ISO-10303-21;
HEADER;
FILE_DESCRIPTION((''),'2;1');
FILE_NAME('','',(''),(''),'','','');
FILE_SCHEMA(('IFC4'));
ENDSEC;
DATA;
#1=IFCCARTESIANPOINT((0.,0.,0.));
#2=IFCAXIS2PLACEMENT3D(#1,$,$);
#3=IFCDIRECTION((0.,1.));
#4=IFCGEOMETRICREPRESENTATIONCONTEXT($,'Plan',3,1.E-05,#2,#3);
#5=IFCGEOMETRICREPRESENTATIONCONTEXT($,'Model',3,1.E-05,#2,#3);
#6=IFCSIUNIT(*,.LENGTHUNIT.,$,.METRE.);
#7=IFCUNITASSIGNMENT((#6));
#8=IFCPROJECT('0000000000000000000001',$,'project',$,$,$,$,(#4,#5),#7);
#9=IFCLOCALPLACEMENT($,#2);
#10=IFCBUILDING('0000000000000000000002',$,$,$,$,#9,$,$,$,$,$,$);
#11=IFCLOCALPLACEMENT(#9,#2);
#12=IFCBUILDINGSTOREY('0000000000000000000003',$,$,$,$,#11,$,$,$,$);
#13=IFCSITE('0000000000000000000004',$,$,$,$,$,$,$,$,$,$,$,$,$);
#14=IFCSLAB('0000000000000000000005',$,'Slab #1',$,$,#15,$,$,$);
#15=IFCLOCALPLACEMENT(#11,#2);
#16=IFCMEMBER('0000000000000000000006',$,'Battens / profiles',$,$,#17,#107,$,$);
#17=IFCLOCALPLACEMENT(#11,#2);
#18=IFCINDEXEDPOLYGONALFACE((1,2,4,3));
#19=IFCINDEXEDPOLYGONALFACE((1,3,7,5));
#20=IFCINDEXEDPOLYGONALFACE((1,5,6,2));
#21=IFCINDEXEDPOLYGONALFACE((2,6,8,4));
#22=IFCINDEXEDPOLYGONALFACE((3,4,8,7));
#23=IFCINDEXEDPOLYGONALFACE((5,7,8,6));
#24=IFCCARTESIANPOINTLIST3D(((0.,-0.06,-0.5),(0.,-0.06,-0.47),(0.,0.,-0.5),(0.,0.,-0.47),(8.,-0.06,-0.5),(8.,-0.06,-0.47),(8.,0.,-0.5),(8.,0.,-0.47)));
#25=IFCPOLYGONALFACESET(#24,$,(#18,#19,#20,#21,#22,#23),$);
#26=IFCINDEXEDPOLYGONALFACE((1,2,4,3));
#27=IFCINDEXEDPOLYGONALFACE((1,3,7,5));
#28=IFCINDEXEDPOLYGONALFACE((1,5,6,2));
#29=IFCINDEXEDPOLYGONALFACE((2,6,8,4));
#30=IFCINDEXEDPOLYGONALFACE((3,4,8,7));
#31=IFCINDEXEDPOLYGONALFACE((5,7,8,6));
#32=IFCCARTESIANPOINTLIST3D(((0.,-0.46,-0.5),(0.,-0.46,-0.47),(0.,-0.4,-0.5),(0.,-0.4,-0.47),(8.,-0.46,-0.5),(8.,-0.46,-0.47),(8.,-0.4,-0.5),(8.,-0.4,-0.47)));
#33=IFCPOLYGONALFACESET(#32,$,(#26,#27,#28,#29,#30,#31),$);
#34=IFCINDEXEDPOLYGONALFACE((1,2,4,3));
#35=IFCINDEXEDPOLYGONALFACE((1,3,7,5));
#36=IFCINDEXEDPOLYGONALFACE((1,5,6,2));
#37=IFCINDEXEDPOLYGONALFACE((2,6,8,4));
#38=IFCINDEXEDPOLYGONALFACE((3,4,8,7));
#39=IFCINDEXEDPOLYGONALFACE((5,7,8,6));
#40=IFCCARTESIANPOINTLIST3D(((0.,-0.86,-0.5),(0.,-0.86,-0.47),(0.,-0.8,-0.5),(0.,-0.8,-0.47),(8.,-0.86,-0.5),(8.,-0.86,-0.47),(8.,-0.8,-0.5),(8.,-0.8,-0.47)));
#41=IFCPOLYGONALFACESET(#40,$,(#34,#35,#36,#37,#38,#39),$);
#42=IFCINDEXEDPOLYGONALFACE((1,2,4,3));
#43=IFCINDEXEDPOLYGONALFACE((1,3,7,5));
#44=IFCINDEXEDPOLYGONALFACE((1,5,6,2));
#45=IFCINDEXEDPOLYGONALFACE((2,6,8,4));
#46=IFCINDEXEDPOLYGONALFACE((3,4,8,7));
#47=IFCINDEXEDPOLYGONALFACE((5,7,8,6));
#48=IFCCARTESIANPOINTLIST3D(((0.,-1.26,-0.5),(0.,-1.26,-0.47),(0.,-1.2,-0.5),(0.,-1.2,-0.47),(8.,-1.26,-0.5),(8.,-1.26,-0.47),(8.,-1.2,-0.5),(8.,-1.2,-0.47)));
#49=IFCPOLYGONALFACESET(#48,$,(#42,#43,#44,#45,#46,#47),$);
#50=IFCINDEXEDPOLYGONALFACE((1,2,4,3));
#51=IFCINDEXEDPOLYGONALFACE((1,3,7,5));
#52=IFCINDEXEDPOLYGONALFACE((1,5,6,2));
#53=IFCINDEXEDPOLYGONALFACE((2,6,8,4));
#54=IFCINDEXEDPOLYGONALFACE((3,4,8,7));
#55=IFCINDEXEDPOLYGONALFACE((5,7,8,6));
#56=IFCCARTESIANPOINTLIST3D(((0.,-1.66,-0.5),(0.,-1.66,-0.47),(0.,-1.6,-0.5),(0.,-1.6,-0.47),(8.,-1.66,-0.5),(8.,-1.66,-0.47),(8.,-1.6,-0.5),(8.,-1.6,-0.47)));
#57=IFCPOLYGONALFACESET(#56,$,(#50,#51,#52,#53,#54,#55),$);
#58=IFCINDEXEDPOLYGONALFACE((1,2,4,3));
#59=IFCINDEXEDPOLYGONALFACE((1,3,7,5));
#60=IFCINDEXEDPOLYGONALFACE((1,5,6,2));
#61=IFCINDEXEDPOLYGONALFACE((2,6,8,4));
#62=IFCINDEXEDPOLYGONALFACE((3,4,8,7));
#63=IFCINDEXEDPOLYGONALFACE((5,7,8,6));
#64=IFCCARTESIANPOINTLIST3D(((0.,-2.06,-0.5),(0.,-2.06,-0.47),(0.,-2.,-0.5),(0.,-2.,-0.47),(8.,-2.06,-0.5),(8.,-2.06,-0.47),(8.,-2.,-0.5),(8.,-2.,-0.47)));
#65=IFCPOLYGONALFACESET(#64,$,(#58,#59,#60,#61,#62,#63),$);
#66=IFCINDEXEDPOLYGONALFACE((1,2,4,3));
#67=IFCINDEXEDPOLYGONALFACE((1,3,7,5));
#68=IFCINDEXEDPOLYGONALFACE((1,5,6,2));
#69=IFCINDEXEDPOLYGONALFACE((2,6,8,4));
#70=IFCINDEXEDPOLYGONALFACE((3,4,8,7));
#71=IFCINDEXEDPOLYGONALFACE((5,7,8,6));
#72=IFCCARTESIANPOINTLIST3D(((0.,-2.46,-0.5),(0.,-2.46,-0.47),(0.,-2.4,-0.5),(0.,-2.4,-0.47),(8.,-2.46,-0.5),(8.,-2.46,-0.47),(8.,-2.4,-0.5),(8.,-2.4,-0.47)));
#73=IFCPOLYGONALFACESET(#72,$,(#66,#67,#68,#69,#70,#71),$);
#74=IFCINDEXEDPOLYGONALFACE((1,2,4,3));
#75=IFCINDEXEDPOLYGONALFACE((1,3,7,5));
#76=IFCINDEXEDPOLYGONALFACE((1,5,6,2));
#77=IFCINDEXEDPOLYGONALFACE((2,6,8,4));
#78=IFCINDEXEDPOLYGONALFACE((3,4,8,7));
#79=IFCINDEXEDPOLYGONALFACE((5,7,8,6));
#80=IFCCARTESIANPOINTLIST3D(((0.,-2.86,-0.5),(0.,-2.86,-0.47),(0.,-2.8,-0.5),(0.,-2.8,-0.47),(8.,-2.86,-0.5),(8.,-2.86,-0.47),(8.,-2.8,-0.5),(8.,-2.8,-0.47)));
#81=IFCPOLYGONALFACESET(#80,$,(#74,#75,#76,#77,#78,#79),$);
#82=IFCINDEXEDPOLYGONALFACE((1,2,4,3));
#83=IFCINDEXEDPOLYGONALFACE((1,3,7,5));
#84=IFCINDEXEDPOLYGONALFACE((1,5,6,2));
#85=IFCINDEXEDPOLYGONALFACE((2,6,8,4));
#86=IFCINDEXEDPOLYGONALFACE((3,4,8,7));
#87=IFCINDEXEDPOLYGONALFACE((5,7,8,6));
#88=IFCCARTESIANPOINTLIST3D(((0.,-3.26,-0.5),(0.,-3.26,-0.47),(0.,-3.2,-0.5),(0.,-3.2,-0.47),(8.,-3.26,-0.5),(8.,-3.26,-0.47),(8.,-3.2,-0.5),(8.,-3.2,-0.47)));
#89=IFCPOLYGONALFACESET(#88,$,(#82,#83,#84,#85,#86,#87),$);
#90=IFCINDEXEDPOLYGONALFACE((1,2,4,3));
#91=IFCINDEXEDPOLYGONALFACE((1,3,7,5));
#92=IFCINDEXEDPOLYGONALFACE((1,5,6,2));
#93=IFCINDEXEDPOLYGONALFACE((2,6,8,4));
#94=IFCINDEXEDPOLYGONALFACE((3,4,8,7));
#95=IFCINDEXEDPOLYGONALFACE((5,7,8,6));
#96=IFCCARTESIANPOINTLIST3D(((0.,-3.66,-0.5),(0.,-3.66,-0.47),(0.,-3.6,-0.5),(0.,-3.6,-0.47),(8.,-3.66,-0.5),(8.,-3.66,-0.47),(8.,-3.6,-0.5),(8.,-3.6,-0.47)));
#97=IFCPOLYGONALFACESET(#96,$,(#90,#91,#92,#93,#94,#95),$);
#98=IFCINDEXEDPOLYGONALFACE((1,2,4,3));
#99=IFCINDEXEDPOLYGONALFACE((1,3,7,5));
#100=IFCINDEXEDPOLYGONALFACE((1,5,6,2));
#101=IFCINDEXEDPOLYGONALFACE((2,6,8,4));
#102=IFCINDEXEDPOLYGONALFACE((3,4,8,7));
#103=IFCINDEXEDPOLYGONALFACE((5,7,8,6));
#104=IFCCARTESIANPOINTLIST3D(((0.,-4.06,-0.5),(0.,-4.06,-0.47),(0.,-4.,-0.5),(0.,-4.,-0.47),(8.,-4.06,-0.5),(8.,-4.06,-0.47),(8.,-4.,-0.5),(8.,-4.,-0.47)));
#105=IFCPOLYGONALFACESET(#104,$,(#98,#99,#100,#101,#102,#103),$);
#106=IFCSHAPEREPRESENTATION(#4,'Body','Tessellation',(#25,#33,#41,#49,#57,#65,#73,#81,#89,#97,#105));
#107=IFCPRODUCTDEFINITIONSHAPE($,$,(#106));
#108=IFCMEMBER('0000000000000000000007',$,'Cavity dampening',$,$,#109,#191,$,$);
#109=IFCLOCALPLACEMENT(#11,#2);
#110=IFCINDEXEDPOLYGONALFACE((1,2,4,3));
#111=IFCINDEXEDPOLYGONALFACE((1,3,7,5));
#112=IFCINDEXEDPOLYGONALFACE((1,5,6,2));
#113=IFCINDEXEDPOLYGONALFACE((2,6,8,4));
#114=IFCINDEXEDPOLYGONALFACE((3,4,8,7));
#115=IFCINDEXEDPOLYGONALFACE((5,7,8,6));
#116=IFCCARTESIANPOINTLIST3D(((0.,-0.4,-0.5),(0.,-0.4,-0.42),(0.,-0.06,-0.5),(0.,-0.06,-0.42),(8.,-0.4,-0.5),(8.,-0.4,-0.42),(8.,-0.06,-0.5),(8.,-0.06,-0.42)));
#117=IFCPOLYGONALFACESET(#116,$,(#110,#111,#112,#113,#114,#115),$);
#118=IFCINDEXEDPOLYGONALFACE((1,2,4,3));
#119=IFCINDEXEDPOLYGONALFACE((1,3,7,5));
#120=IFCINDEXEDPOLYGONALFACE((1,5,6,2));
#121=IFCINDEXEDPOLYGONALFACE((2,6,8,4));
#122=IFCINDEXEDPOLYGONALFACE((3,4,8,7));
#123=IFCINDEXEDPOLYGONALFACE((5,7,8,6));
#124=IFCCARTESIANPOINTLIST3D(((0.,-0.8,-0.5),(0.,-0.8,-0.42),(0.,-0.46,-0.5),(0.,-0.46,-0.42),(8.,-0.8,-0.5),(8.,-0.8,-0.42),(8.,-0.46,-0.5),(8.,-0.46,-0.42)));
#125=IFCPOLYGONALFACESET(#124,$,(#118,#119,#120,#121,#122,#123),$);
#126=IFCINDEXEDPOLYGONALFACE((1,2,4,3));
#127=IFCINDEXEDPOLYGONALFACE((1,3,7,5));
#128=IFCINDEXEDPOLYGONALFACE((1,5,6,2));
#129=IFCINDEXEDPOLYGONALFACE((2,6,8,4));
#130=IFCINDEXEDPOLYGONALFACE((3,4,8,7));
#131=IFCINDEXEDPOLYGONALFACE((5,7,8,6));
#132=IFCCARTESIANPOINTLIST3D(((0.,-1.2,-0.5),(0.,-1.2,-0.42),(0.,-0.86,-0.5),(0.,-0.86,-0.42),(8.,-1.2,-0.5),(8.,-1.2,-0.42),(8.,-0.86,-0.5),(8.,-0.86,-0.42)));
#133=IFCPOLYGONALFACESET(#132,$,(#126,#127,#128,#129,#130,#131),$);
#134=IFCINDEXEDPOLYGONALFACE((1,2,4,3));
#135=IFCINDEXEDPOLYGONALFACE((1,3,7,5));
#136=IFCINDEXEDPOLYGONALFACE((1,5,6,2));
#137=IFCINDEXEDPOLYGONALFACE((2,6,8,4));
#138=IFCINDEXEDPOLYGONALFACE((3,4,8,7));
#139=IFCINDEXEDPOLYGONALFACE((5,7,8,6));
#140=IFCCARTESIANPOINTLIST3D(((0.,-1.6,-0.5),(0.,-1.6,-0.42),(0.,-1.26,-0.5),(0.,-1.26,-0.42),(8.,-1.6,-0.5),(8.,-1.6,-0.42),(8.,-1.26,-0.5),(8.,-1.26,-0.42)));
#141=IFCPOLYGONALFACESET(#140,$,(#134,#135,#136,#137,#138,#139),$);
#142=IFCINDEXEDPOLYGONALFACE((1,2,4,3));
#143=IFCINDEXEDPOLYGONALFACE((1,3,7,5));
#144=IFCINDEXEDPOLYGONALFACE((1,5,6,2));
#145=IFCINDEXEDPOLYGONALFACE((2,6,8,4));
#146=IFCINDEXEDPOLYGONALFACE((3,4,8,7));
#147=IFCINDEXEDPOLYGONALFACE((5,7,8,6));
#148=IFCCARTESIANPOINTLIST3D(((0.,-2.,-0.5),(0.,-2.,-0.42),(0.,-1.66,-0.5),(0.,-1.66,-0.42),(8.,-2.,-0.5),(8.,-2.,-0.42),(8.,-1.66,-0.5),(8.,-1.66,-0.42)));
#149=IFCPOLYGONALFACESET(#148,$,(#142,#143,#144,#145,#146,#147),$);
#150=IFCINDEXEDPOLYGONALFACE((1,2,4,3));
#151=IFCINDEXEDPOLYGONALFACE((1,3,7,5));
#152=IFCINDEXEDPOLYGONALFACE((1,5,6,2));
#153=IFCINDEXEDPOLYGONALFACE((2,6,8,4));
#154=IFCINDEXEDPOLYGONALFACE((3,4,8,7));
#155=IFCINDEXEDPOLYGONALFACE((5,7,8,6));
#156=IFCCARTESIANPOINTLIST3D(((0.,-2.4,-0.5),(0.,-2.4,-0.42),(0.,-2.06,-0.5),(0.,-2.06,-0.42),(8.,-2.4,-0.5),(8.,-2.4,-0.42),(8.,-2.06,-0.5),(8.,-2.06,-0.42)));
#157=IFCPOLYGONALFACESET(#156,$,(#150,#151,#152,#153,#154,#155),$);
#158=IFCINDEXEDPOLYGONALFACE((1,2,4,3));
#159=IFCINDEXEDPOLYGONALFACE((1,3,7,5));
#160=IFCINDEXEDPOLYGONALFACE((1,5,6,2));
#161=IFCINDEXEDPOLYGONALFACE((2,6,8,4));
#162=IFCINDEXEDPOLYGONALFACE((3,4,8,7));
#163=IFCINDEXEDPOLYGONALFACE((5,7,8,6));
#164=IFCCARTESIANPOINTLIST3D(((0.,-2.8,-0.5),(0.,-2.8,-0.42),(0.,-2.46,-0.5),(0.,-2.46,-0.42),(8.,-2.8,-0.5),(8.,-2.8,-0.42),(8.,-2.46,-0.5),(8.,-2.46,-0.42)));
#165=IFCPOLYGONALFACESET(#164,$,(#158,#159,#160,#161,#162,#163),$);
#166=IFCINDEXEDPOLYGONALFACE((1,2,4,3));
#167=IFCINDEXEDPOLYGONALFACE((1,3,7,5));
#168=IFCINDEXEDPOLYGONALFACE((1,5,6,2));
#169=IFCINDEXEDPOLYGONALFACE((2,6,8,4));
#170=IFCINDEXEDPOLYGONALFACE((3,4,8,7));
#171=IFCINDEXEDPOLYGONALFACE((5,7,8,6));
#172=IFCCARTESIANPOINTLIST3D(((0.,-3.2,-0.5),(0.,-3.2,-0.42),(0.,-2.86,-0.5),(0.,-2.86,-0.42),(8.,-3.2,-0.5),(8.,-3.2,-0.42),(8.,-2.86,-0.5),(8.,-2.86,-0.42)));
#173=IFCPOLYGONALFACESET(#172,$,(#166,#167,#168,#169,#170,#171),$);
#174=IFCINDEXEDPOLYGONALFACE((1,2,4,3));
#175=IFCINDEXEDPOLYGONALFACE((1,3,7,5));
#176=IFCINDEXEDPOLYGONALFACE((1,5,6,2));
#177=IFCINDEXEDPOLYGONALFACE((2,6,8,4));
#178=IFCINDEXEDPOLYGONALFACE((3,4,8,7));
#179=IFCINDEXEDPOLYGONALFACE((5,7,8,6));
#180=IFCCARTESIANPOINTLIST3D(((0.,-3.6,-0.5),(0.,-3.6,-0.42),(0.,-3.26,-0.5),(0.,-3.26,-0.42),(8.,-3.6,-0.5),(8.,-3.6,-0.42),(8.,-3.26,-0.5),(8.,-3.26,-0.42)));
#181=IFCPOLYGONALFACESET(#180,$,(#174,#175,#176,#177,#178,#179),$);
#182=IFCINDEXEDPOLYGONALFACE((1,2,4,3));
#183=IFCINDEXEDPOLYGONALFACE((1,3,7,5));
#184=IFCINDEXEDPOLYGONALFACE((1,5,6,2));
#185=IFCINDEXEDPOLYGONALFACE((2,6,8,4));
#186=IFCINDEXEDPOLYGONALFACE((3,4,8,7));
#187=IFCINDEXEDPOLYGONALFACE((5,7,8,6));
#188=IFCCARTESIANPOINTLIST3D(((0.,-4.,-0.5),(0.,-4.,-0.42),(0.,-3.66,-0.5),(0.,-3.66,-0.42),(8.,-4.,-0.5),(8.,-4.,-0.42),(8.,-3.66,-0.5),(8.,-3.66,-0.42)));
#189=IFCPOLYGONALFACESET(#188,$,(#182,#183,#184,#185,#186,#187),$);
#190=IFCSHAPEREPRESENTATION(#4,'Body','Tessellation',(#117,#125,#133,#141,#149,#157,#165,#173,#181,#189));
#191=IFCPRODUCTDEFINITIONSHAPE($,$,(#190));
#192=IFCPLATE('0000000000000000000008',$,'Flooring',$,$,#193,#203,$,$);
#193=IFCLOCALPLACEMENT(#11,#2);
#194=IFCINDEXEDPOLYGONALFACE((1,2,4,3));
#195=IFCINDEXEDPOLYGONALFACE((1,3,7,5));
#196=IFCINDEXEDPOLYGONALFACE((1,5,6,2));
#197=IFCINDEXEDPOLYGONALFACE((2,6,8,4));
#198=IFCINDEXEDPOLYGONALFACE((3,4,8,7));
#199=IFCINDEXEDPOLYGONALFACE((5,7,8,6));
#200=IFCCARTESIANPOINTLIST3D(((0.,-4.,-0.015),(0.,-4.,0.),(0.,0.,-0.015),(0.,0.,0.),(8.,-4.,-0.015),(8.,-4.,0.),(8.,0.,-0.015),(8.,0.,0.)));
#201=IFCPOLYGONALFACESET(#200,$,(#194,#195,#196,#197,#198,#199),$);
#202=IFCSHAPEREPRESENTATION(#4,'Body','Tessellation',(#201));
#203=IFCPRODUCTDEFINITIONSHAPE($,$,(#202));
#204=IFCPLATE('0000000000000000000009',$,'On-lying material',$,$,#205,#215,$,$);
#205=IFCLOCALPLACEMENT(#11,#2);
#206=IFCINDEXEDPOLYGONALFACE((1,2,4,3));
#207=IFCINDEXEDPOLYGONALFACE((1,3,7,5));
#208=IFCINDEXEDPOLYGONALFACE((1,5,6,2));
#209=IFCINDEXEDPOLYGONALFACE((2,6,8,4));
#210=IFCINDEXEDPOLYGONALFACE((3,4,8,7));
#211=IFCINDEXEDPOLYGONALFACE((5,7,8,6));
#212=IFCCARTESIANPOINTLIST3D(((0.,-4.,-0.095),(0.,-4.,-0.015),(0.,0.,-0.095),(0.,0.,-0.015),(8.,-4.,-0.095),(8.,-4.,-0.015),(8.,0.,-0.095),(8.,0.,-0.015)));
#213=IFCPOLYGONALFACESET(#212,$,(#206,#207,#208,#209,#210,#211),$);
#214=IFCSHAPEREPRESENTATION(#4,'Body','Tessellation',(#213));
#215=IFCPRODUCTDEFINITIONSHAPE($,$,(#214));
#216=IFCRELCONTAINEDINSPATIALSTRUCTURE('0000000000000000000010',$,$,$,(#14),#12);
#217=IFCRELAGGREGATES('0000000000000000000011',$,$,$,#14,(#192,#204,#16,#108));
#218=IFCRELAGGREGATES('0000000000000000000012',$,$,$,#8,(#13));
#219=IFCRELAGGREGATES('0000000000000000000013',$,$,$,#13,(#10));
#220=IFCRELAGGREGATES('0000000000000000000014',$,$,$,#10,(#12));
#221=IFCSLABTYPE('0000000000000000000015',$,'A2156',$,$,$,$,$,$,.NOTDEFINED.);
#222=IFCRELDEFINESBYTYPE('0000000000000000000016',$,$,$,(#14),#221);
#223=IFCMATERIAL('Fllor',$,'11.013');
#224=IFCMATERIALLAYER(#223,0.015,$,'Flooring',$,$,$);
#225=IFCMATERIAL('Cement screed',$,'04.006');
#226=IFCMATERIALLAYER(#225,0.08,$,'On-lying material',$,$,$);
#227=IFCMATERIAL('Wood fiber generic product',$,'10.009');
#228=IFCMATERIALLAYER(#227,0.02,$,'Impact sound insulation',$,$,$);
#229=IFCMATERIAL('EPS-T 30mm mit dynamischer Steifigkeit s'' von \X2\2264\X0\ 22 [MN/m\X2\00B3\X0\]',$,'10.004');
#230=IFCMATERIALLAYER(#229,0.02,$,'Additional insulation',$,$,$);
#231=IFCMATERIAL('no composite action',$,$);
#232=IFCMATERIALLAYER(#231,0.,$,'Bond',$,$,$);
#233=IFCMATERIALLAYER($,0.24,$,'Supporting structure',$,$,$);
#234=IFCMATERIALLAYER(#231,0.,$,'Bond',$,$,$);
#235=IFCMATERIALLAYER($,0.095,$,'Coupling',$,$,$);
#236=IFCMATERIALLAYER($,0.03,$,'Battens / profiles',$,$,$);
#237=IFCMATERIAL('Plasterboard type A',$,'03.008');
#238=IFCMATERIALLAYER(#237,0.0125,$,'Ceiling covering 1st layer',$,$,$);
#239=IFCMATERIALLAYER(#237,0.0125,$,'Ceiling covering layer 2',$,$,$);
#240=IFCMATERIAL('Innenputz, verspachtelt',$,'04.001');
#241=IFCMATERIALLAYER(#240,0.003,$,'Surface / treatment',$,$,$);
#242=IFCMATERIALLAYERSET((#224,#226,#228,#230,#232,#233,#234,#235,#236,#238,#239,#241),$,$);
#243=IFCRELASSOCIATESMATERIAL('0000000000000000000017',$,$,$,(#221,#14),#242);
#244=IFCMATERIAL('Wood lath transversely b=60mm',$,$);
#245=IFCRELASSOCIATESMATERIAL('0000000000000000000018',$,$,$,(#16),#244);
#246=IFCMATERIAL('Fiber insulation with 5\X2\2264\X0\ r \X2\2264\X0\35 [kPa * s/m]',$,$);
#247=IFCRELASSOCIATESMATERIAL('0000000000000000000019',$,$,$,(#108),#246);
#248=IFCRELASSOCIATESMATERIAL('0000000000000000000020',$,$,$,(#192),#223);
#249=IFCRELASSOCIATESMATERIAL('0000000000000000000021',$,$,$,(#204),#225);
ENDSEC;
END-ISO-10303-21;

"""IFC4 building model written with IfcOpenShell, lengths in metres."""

from ifc_helpers import new_model, si_unit, direction, frame, frame_2d, origin, origin_with_axes, place, context, project, spatial, rectangle, extrude, material, layer, layer_set, type_object, element, aggregate, save


model = new_model("IFC4")

# Units and contexts
plan_context = context("Plan", 3, precision=1e-05, world=origin(), true_north=direction((0.0, 1.0)))
model_context = context("Model", 3, precision=1e-05, world=origin(), true_north=direction((0.0, 1.0)))
ifc_project = project(units=[si_unit("LENGTHUNIT", "METRE")], contexts=[plan_context, model_context])

# Site, building, storey
site = spatial("IfcSite", under=ifc_project)
building_placement = place(None, origin())
building = spatial("IfcBuilding", under=site, at=building_placement)
storey_placement = place(building_placement, origin())
storey = spatial("IfcBuildingStorey", under=building, at=storey_placement)

# Slab, members, plates
ifc_material_1 = material(Name="Fllor", Category="11.013")
ifc_layer_1 = layer(ifc_material_1, 0.015, Name="Flooring")
ifc_material_2 = material(Name="Cement screed", Category="04.006")
ifc_layer_2 = layer(ifc_material_2, 0.08, Name="On-lying material")
ifc_material_3 = material(Name="Wood fiber generic product", Category="10.009")
ifc_layer_3 = layer(ifc_material_3, 0.02, Name="Impact sound insulation")
ifc_material_4 = material(Name="EPS-T 30mm mit dynamischer Steifigkeit s' von ≤ 22 [MN/m³]", Category="10.004")
ifc_layer_4 = layer(ifc_material_4, 0.02, Name="Additional insulation")
ifc_material_5 = material(Name="no composite action")
ifc_layer_5 = layer(ifc_material_5, 0.0, Name="Bond")
ifc_layer_6 = layer(None, 0.24, Name="Supporting structure")
ifc_layer_7 = layer(ifc_material_5, 0.0, Name="Bond")
ifc_layer_8 = layer(None, 0.095, Name="Coupling")
ifc_layer_9 = layer(None, 0.03, Name="Battens / profiles")
ifc_material_6 = material(Name="Plasterboard type A", Category="03.008")
ifc_layer_10 = layer(ifc_material_6, 0.0125, Name="Ceiling covering 1st layer")
ifc_layer_11 = layer(ifc_material_6, 0.0125, Name="Ceiling covering layer 2")
ifc_material_7 = material(Name="Innenputz, verspachtelt", Category="04.001")
ifc_layer_12 = layer(ifc_material_7, 0.003, Name="Surface / treatment")
ifc_layer_set = layer_set([ifc_layer_1, ifc_layer_2, ifc_layer_3, ifc_layer_4, ifc_layer_5, ifc_layer_6, ifc_layer_7, ifc_layer_8, ifc_layer_9, ifc_layer_10, ifc_layer_11, ifc_layer_12])
slab_type = type_object("IfcSlabType", Name="A2156", PredefinedType="NOTDEFINED", material=ifc_layer_set)
slab_placement = place(None, frame((0.0, 0.0, 0.0), z_axis=(0.0, 0.0, -1.0), x_axis=(1.0, 0.0, 0.0)))
slab = element("IfcSlab", 1, at=slab_placement, inside=storey, type_object=slab_type, material=ifc_layer_set, Name="Slab #1")
ifc_material_8 = material(Name="Wood lath transversely b=60mm")
member_1_placement = place(slab_placement, origin())
member_1 = element("IfcMember", 2, at=member_1_placement, material=ifc_material_8, Name="Battens / profiles", context=plan_context, shape_type="SweptSolid", body=[
    extrude(rectangle(XDim=0.06, YDim=0.03, at=frame_2d((0.03, 0.015), x_axis=(1.0, 0.0))), frame((0.0, 0.0, 0.47), z_axis=(1.0, 0.0, 0.0), x_axis=(0.0, 1.0, 0.0)), (0.0, 0.0, 1.0), 8.0),
    extrude(rectangle(XDim=0.06, YDim=0.03, at=frame_2d((0.03, 0.015), x_axis=(1.0, 0.0))), frame((0.0, 0.4, 0.47), z_axis=(1.0, 0.0, 0.0), x_axis=(0.0, 1.0, 0.0)), (0.0, 0.0, 1.0), 8.0),
    extrude(rectangle(XDim=0.06, YDim=0.03, at=frame_2d((0.03, 0.015), x_axis=(1.0, 0.0))), frame((0.0, 0.8, 0.47), z_axis=(1.0, 0.0, 0.0), x_axis=(0.0, 1.0, 0.0)), (0.0, 0.0, 1.0), 8.0),
    extrude(rectangle(XDim=0.06, YDim=0.03, at=frame_2d((0.03, 0.015), x_axis=(1.0, 0.0))), frame((0.0, 1.2, 0.47), z_axis=(1.0, 0.0, 0.0), x_axis=(0.0, 1.0, 0.0)), (0.0, 0.0, 1.0), 8.0),
    extrude(rectangle(XDim=0.06, YDim=0.03, at=frame_2d((0.03, 0.015), x_axis=(1.0, 0.0))), frame((0.0, 1.6, 0.47), z_axis=(1.0, 0.0, 0.0), x_axis=(0.0, 1.0, 0.0)), (0.0, 0.0, 1.0), 8.0),
    extrude(rectangle(XDim=0.06, YDim=0.03, at=frame_2d((0.03, 0.015), x_axis=(1.0, 0.0))), frame((0.0, 2.0, 0.47), z_axis=(1.0, 0.0, 0.0), x_axis=(0.0, 1.0, 0.0)), (0.0, 0.0, 1.0), 8.0),
    extrude(rectangle(XDim=0.06, YDim=0.03, at=frame_2d((0.03, 0.015), x_axis=(1.0, 0.0))), frame((0.0, 2.4, 0.47), z_axis=(1.0, 0.0, 0.0), x_axis=(0.0, 1.0, 0.0)), (0.0, 0.0, 1.0), 8.0),
    extrude(rectangle(XDim=0.06, YDim=0.03, at=frame_2d((0.03, 0.015), x_axis=(1.0, 0.0))), frame((0.0, 2.8, 0.47), z_axis=(1.0, 0.0, 0.0), x_axis=(0.0, 1.0, 0.0)), (0.0, 0.0, 1.0), 8.0),
    extrude(rectangle(XDim=0.06, YDim=0.03, at=frame_2d((0.03, 0.015), x_axis=(1.0, 0.0))), frame((0.0, 3.2, 0.47), z_axis=(1.0, 0.0, 0.0), x_axis=(0.0, 1.0, 0.0)), (0.0, 0.0, 1.0), 8.0),
    extrude(rectangle(XDim=0.06, YDim=0.03, at=frame_2d((0.03, 0.015), x_axis=(1.0, 0.0))), frame((0.0, 3.6, 0.47), z_axis=(1.0, 0.0, 0.0), x_axis=(0.0, 1.0, 0.0)), (0.0, 0.0, 1.0), 8.0),
    extrude(rectangle(XDim=0.06, YDim=0.03, at=frame_2d((0.03, 0.015), x_axis=(1.0, 0.0))), frame((0.0, 4.0, 0.47), z_axis=(1.0, 0.0, 0.0), x_axis=(0.0, 1.0, 0.0)), (0.0, 0.0, 1.0), 8.0),
])
ifc_material_9 = material(Name="Fiber insulation with 5≤ r ≤35 [kPa * s/m]")
member_2_placement = place(slab_placement, origin())
member_2 = element("IfcMember", 3, at=member_2_placement, material=ifc_material_9, Name="Cavity dampening", context=plan_context, shape_type="SweptSolid", body=[
    extrude(rectangle(XDim=0.34, YDim=0.08, at=frame_2d((0.17, 0.04), x_axis=(1.0, 0.0))), frame((0.0, 0.06, 0.42), z_axis=(1.0, 0.0, 0.0), x_axis=(0.0, 1.0, 0.0)), (0.0, 0.0, 1.0), 8.0),
    extrude(rectangle(XDim=0.34, YDim=0.08, at=frame_2d((0.17, 0.04), x_axis=(1.0, 0.0))), frame((0.0, 0.46, 0.42), z_axis=(1.0, 0.0, 0.0), x_axis=(0.0, 1.0, 0.0)), (0.0, 0.0, 1.0), 8.0),
    extrude(rectangle(XDim=0.34, YDim=0.08, at=frame_2d((0.17, 0.04), x_axis=(1.0, 0.0))), frame((0.0, 0.86, 0.42), z_axis=(1.0, 0.0, 0.0), x_axis=(0.0, 1.0, 0.0)), (0.0, 0.0, 1.0), 8.0),
    extrude(rectangle(XDim=0.34, YDim=0.08, at=frame_2d((0.17, 0.04), x_axis=(1.0, 0.0))), frame((0.0, 1.26, 0.42), z_axis=(1.0, 0.0, 0.0), x_axis=(0.0, 1.0, 0.0)), (0.0, 0.0, 1.0), 8.0),
    extrude(rectangle(XDim=0.34, YDim=0.08, at=frame_2d((0.17, 0.04), x_axis=(1.0, 0.0))), frame((0.0, 1.66, 0.42), z_axis=(1.0, 0.0, 0.0), x_axis=(0.0, 1.0, 0.0)), (0.0, 0.0, 1.0), 8.0),
    extrude(rectangle(XDim=0.34, YDim=0.08, at=frame_2d((0.17, 0.04), x_axis=(1.0, 0.0))), frame((0.0, 2.06, 0.42), z_axis=(1.0, 0.0, 0.0), x_axis=(0.0, 1.0, 0.0)), (0.0, 0.0, 1.0), 8.0),
    extrude(rectangle(XDim=0.34, YDim=0.08, at=frame_2d((0.17, 0.04), x_axis=(1.0, 0.0))), frame((0.0, 2.46, 0.42), z_axis=(1.0, 0.0, 0.0), x_axis=(0.0, 1.0, 0.0)), (0.0, 0.0, 1.0), 8.0),
    extrude(rectangle(XDim=0.34, YDim=0.08, at=frame_2d((0.17, 0.04), x_axis=(1.0, 0.0))), frame((0.0, 2.86, 0.42), z_axis=(1.0, 0.0, 0.0), x_axis=(0.0, 1.0, 0.0)), (0.0, 0.0, 1.0), 8.0),
    extrude(rectangle(XDim=0.34, YDim=0.08, at=frame_2d((0.17, 0.04), x_axis=(1.0, 0.0))), frame((0.0, 3.26, 0.42), z_axis=(1.0, 0.0, 0.0), x_axis=(0.0, 1.0, 0.0)), (0.0, 0.0, 1.0), 8.0),
    extrude(rectangle(XDim=0.34, YDim=0.08, at=frame_2d((0.17, 0.04), x_axis=(1.0, 0.0))), frame((0.0, 3.66, 0.42), z_axis=(1.0, 0.0, 0.0), x_axis=(0.0, 1.0, 0.0)), (0.0, 0.0, 1.0), 8.0),
])
plate_1_placement = place(slab_placement, origin())
plate_1 = element("IfcPlate", 4, at=plate_1_placement, material=ifc_material_1, Name="Flooring", context=plan_context, shape_type="SweptSolid", body=[
    extrude(rectangle(XDim=8.0, YDim=4.0, at=frame_2d((4.0, 2.0), x_axis=(1.0, 0.0))), origin_with_axes(), (0.0, 0.0, 1.0), 0.015),
])
plate_2_placement = place(slab_placement, origin())
plate_2 = element("IfcPlate", 5, at=plate_2_placement, material=ifc_material_2, Name="On-lying material", context=plan_context, shape_type="SweptSolid", body=[
    extrude(rectangle(XDim=8.0, YDim=4.0, at=frame_2d((4.0, 2.0), x_axis=(1.0, 0.0))), frame((0.0, 0.0, 0.015), z_axis=(0.0, 0.0, 1.0), x_axis=(1.0, 0.0, 0.0)), (0.0, 0.0, 1.0), 0.08),
])
aggregate(slab, [plate_1, plate_2, member_1, member_2])

save(model, "model.ifc")
